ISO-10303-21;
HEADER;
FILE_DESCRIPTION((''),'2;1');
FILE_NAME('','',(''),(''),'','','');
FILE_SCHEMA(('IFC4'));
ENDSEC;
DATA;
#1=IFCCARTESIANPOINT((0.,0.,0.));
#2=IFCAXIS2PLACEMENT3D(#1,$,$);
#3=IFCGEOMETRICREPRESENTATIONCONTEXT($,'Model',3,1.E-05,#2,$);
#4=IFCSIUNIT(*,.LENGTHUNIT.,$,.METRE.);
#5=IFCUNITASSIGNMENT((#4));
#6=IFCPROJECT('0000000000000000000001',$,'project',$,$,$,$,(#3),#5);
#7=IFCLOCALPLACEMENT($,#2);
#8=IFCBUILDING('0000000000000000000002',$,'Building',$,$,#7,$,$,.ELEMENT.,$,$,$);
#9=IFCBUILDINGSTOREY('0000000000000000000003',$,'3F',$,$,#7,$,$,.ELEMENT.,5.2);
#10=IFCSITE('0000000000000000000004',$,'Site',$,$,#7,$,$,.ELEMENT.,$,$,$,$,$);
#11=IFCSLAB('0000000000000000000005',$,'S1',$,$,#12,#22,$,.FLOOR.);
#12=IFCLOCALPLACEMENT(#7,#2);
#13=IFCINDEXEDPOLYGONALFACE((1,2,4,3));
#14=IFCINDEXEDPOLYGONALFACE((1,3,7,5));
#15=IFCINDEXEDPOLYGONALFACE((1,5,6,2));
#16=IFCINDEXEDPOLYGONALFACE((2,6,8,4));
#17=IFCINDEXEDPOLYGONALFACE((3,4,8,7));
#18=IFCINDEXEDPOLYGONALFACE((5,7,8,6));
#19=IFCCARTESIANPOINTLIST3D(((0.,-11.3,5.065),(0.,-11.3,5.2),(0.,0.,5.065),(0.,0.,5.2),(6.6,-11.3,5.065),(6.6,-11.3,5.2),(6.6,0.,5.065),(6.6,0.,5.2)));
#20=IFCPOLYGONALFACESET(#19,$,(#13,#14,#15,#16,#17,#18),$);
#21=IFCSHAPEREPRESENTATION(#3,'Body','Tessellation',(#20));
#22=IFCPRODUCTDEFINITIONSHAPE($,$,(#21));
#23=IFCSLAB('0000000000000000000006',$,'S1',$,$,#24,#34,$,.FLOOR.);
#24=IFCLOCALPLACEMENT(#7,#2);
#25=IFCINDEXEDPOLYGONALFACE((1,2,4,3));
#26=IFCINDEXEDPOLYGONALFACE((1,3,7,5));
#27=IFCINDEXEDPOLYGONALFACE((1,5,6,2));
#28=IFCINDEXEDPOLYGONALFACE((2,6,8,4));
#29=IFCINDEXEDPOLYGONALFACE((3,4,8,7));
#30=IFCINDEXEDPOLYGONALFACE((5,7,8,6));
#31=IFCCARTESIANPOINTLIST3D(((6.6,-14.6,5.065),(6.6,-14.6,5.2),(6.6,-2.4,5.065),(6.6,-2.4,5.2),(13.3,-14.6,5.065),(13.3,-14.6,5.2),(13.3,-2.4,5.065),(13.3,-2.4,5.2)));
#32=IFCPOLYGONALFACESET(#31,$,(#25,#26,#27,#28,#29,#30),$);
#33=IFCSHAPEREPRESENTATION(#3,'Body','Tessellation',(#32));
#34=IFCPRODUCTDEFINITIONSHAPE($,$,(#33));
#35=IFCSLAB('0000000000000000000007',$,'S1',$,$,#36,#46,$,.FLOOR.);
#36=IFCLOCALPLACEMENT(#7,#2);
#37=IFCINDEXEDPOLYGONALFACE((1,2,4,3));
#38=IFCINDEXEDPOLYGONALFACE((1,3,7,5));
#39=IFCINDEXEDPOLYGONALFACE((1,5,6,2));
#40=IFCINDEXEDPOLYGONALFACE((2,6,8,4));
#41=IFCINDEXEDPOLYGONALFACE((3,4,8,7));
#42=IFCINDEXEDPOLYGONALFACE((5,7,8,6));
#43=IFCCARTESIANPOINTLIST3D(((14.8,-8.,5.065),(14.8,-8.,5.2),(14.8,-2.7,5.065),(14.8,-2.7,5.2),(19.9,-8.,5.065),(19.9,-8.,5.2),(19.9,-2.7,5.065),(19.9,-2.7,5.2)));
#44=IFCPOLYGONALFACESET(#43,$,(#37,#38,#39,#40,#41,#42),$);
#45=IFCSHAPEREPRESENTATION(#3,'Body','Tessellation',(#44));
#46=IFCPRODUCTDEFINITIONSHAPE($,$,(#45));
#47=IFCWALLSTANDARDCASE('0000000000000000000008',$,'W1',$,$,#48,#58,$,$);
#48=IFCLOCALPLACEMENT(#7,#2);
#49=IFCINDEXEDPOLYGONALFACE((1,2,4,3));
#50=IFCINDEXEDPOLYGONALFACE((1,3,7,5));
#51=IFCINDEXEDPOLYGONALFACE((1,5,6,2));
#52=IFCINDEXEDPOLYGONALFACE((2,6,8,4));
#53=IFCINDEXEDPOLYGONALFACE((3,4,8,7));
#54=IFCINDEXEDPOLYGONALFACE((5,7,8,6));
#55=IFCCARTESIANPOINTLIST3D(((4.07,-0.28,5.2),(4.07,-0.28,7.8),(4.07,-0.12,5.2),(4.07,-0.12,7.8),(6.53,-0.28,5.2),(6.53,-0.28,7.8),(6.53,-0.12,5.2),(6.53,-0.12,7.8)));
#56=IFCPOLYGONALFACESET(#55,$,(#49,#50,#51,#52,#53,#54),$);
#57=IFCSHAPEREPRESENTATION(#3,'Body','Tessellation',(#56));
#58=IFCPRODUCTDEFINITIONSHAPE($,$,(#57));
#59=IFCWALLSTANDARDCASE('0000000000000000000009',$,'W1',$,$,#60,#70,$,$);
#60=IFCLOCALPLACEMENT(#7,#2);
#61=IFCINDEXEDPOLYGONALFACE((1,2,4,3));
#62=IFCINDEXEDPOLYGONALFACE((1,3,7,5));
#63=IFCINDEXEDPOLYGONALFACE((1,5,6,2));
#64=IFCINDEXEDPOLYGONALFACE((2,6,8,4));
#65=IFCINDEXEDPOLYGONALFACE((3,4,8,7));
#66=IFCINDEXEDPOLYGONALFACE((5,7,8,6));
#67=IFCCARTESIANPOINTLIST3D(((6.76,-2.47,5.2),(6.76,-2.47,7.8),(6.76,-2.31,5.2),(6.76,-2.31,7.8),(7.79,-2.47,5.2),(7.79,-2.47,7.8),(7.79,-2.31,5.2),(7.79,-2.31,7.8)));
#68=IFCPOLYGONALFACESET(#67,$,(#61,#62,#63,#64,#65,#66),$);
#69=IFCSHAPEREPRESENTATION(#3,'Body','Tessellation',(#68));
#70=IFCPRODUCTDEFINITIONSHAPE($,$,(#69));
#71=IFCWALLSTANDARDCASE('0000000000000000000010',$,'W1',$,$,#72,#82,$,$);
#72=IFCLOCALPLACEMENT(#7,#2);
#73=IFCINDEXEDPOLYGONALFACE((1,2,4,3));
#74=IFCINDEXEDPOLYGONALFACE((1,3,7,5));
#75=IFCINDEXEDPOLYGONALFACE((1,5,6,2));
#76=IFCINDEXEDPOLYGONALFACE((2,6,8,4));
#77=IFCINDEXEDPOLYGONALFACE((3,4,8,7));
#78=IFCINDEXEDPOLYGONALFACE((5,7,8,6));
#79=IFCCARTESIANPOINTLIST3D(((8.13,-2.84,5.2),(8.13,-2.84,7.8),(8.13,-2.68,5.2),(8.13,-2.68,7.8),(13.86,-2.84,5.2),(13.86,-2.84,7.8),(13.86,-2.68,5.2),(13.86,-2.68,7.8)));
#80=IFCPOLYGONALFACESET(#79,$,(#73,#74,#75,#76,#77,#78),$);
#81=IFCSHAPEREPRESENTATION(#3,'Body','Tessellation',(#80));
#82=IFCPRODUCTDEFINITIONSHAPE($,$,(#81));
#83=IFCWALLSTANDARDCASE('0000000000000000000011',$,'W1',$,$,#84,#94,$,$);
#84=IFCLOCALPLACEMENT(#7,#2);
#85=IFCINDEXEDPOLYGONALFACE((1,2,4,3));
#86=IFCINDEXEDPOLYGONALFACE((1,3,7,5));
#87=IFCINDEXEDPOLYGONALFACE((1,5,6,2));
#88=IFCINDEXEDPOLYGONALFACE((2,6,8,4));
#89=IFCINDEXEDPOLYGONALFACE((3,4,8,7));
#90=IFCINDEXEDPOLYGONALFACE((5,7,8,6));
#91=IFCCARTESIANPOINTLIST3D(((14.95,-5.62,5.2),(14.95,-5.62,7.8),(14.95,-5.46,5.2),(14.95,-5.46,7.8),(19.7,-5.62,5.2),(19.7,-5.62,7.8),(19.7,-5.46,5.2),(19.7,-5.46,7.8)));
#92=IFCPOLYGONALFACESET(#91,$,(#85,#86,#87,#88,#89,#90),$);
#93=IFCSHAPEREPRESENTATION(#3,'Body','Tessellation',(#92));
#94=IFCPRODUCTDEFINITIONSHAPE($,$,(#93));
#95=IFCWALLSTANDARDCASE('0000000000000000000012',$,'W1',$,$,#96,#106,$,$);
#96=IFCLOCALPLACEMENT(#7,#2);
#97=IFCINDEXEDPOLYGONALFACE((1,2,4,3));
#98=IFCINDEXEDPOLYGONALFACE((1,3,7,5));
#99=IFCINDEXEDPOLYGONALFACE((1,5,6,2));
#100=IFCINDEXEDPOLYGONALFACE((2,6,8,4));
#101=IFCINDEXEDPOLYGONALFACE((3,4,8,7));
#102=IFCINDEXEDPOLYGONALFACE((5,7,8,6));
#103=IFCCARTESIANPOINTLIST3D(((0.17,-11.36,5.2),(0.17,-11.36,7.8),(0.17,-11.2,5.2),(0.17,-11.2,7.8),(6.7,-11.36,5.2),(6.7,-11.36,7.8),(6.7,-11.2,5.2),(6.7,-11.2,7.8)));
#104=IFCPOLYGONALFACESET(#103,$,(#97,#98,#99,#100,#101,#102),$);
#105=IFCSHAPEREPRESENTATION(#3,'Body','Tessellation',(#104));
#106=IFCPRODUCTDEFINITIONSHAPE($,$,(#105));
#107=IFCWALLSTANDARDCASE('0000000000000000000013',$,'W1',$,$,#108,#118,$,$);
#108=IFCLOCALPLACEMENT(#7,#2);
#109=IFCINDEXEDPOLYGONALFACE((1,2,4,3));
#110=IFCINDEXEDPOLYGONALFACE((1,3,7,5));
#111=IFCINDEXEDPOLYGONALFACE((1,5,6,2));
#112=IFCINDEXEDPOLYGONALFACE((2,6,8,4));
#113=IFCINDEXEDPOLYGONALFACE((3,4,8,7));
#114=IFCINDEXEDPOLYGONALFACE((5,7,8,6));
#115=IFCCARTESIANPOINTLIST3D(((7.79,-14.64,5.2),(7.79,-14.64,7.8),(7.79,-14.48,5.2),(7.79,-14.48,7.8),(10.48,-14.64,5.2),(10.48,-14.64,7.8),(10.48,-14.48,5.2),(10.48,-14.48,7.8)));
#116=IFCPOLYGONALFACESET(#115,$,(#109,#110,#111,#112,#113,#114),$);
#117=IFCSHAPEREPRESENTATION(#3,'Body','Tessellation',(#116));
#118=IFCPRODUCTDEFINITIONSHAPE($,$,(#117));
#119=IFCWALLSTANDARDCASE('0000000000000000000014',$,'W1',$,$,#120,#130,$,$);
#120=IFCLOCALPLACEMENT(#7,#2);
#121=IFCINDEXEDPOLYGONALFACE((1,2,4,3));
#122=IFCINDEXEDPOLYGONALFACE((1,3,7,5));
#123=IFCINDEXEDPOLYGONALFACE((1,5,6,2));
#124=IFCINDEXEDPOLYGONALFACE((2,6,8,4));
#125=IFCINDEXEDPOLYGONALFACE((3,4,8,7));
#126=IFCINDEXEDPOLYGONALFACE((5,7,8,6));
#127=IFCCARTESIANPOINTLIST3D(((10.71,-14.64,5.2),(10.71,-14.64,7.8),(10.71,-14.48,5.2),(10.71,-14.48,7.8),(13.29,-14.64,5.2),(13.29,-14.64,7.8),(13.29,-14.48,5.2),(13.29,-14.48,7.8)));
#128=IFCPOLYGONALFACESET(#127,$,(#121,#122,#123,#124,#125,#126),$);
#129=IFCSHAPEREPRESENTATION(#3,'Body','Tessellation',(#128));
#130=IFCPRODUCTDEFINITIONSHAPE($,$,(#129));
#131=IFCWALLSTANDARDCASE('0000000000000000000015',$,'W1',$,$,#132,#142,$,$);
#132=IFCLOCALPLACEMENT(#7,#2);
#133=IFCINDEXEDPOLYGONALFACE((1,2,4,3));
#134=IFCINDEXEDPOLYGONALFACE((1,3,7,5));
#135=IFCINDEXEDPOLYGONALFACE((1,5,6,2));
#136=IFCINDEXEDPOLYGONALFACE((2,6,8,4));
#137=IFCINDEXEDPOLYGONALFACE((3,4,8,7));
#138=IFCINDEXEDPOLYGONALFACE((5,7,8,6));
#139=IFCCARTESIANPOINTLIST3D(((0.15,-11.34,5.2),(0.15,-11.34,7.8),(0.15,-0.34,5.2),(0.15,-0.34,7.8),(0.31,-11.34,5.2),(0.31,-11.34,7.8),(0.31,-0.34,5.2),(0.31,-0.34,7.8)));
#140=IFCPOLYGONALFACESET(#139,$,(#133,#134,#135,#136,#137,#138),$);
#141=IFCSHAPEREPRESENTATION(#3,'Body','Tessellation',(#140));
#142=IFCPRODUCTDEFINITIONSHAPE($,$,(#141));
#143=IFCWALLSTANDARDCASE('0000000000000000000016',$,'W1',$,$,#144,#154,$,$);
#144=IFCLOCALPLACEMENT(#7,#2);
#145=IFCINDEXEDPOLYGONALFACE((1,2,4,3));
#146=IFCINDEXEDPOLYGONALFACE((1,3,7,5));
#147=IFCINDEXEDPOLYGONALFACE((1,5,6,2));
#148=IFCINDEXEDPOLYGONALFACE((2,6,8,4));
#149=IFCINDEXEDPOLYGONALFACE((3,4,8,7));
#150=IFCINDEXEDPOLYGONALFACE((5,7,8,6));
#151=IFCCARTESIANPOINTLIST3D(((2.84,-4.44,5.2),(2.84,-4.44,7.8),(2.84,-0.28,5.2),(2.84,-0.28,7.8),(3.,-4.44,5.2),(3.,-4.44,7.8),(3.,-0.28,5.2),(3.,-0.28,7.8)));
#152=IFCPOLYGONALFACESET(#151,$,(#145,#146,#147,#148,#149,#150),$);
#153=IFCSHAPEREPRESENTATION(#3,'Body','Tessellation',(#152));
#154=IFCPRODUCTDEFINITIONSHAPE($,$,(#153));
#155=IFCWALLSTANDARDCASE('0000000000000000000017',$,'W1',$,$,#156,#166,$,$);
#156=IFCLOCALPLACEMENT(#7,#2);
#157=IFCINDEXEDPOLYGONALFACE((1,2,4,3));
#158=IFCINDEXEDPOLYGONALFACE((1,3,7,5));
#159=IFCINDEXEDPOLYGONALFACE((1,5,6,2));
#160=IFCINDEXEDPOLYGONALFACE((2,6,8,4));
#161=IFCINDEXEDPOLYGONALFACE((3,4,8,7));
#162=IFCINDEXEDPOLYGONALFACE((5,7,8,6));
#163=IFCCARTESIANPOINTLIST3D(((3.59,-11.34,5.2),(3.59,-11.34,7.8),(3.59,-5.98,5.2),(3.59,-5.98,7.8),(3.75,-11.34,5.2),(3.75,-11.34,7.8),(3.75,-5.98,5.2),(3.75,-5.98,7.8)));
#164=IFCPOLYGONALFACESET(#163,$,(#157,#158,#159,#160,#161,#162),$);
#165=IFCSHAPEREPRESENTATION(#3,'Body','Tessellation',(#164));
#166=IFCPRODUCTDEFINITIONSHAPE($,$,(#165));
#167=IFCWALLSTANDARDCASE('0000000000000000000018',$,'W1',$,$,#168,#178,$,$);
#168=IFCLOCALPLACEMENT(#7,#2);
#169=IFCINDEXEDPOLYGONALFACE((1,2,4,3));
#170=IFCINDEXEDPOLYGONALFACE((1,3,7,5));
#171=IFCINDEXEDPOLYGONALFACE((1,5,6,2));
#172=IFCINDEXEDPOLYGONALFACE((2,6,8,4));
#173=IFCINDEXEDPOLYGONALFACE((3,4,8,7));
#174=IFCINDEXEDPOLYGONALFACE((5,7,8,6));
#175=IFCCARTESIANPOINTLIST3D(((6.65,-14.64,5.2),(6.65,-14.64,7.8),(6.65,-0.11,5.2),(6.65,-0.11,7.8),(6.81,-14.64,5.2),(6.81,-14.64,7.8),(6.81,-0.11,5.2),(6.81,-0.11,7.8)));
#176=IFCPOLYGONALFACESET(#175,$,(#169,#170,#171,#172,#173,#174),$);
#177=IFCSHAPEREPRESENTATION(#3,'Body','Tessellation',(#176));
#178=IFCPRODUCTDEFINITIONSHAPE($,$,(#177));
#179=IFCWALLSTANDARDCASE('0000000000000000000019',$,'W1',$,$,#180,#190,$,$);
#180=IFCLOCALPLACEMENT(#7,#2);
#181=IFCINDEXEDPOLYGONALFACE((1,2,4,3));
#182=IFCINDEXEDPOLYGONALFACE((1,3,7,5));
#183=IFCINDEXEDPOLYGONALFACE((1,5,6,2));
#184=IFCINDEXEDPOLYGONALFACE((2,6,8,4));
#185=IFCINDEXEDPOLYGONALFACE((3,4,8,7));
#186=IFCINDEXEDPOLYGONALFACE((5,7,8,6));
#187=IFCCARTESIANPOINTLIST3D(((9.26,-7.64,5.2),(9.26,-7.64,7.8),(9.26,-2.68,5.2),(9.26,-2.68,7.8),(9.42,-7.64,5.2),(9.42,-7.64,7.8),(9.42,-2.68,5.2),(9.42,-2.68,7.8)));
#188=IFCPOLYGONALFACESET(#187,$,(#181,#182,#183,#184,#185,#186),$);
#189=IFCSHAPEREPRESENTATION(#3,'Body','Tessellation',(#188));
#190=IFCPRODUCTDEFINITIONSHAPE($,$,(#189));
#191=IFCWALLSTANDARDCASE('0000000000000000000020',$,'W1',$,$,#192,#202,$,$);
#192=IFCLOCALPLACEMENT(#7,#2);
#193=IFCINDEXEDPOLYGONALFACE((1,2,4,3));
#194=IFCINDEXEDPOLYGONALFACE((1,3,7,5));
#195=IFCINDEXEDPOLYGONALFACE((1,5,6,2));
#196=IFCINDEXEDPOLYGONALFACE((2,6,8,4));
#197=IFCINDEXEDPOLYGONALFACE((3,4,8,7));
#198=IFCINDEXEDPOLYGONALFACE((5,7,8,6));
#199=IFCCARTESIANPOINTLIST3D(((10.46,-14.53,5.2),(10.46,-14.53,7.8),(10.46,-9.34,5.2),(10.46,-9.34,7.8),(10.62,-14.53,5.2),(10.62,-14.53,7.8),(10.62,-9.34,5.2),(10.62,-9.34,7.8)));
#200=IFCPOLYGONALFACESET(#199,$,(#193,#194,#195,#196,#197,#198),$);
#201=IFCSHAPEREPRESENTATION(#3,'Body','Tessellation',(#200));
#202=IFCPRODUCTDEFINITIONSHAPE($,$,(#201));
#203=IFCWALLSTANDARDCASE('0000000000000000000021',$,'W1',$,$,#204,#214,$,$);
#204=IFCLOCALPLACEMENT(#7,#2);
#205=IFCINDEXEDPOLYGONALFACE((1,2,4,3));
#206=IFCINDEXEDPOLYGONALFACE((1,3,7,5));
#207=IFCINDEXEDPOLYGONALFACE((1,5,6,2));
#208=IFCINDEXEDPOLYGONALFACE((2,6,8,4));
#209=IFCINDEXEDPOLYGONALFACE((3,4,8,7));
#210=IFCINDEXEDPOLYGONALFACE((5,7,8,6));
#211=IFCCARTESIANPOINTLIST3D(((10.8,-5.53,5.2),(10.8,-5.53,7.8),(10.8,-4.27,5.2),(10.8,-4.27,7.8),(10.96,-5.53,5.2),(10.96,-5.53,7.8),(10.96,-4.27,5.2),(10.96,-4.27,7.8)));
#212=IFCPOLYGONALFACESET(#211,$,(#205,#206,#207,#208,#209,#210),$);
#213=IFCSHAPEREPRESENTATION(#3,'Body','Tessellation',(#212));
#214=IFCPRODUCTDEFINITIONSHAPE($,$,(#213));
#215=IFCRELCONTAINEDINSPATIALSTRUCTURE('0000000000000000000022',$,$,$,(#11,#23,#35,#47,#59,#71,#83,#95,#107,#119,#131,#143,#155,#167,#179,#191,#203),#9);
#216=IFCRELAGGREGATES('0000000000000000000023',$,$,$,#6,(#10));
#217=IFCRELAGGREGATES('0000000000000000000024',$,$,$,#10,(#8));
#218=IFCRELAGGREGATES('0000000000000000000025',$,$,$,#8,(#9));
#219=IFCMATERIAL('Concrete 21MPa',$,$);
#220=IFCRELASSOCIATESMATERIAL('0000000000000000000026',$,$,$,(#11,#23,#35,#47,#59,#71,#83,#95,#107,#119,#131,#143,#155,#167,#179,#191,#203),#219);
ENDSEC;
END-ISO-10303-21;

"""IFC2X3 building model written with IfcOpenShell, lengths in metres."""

from ifc_helpers import new_model, si_unit, frame, origin, origin_2d, place, context, project, spatial, rectangle, extrude, material, element, save


model = new_model("IFC2X3")

# Units and contexts
model_context = context("Model", 3, precision=1e-05, world=origin())
ifc_project = project(units=[si_unit("LENGTHUNIT", "METRE")], contexts=[model_context])

# Site, building, storey
placement = place(None, origin())
site = spatial("IfcSite", under=ifc_project, at=placement, Name="Site", CompositionType="ELEMENT")
building = spatial("IfcBuilding", under=site, at=placement, Name="Building", CompositionType="ELEMENT")
storey = spatial("IfcBuildingStorey", under=building, at=placement, Name="3F", CompositionType="ELEMENT", Elevation=5.2)

# Slabs
ifc_material_1 = material(Name="Concrete 21MPa")
slab_1_placement = place(None, frame((3.3, -5.65, 5.065)))
element("IfcSlab", 1, at=slab_1_placement, inside=storey, material=ifc_material_1, Name="S1", PredefinedType="FLOOR", context=model_context, shape_type="SweptSolid", body=[
    extrude(rectangle(XDim=6.6, YDim=11.3, at=origin_2d()), origin(), (0.0, 0.0, 1.0), 0.135),
])
slab_2_placement = place(None, frame((9.95, -8.5, 5.065)))
element("IfcSlab", 2, at=slab_2_placement, inside=storey, material=ifc_material_1, Name="S1", PredefinedType="FLOOR", context=model_context, shape_type="SweptSolid", body=[
    extrude(rectangle(XDim=6.7, YDim=12.2, at=origin_2d()), origin(), (0.0, 0.0, 1.0), 0.135),
])
slab_3_placement = place(None, frame((17.35, -5.35, 5.065)))
element("IfcSlab", 3, at=slab_3_placement, inside=storey, material=ifc_material_1, Name="S1", PredefinedType="FLOOR", context=model_context, shape_type="SweptSolid", body=[
    extrude(rectangle(XDim=5.1, YDim=5.3, at=origin_2d()), origin(), (0.0, 0.0, 1.0), 0.135),
])

# Walls
wall_1_placement = place(None, frame((5.3, -0.2, 5.2)))
element("IfcWallStandardCase", 4, at=wall_1_placement, inside=storey, material=ifc_material_1, Name="W1", context=model_context, shape_type="SweptSolid", body=[
    extrude(rectangle(XDim=2.46, YDim=0.16, at=origin_2d()), origin(), (0.0, 0.0, 1.0), 2.6),
])
wall_2_placement = place(None, frame((7.275, -2.39, 5.2)))
element("IfcWallStandardCase", 5, at=wall_2_placement, inside=storey, material=ifc_material_1, Name="W1", context=model_context, shape_type="SweptSolid", body=[
    extrude(rectangle(XDim=1.03, YDim=0.16, at=origin_2d()), origin(), (0.0, 0.0, 1.0), 2.6),
])
wall_3_placement = place(None, frame((10.995, -2.76, 5.2)))
element("IfcWallStandardCase", 6, at=wall_3_placement, inside=storey, material=ifc_material_1, Name="W1", context=model_context, shape_type="SweptSolid", body=[
    extrude(rectangle(XDim=5.73, YDim=0.16, at=origin_2d()), origin(), (0.0, 0.0, 1.0), 2.6),
])
wall_4_placement = place(None, frame((17.325, -5.54, 5.2)))
element("IfcWallStandardCase", 7, at=wall_4_placement, inside=storey, material=ifc_material_1, Name="W1", context=model_context, shape_type="SweptSolid", body=[
    extrude(rectangle(XDim=4.75, YDim=0.16, at=origin_2d()), origin(), (0.0, 0.0, 1.0), 2.6),
])
wall_5_placement = place(None, frame((3.435, -11.28, 5.2)))
element("IfcWallStandardCase", 8, at=wall_5_placement, inside=storey, material=ifc_material_1, Name="W1", context=model_context, shape_type="SweptSolid", body=[
    extrude(rectangle(XDim=6.53, YDim=0.16, at=origin_2d()), origin(), (0.0, 0.0, 1.0), 2.6),
])
wall_6_placement = place(None, frame((9.135, -14.56, 5.2)))
element("IfcWallStandardCase", 9, at=wall_6_placement, inside=storey, material=ifc_material_1, Name="W1", context=model_context, shape_type="SweptSolid", body=[
    extrude(rectangle(XDim=2.69, YDim=0.16, at=origin_2d()), origin(), (0.0, 0.0, 1.0), 2.6),
])
wall_7_placement = place(None, frame((12.0, -14.56, 5.2)))
element("IfcWallStandardCase", 10, at=wall_7_placement, inside=storey, material=ifc_material_1, Name="W1", context=model_context, shape_type="SweptSolid", body=[
    extrude(rectangle(XDim=2.58, YDim=0.16, at=origin_2d()), origin(), (0.0, 0.0, 1.0), 2.6),
])
wall_8_placement = place(None, frame((0.23, -5.84, 5.2)))
element("IfcWallStandardCase", 11, at=wall_8_placement, inside=storey, material=ifc_material_1, Name="W1", context=model_context, shape_type="SweptSolid", body=[
    extrude(rectangle(XDim=0.16, YDim=11.0, at=origin_2d()), origin(), (0.0, 0.0, 1.0), 2.6),
])
wall_9_placement = place(None, frame((2.92, -2.36, 5.2)))
element("IfcWallStandardCase", 12, at=wall_9_placement, inside=storey, material=ifc_material_1, Name="W1", context=model_context, shape_type="SweptSolid", body=[
    extrude(rectangle(XDim=0.16, YDim=4.16, at=origin_2d()), origin(), (0.0, 0.0, 1.0), 2.6),
])
wall_10_placement = place(None, frame((3.67, -8.66, 5.2)))
element("IfcWallStandardCase", 13, at=wall_10_placement, inside=storey, material=ifc_material_1, Name="W1", context=model_context, shape_type="SweptSolid", body=[
    extrude(rectangle(XDim=0.16, YDim=5.36, at=origin_2d()), origin(), (0.0, 0.0, 1.0), 2.6),
])
wall_11_placement = place(None, frame((6.73, -7.375, 5.2)))
element("IfcWallStandardCase", 14, at=wall_11_placement, inside=storey, material=ifc_material_1, Name="W1", context=model_context, shape_type="SweptSolid", body=[
    extrude(rectangle(XDim=0.16, YDim=14.53, at=origin_2d()), origin(), (0.0, 0.0, 1.0), 2.6),
])
wall_12_placement = place(None, frame((9.34, -5.16, 5.2)))
element("IfcWallStandardCase", 15, at=wall_12_placement, inside=storey, material=ifc_material_1, Name="W1", context=model_context, shape_type="SweptSolid", body=[
    extrude(rectangle(XDim=0.16, YDim=4.96, at=origin_2d()), origin(), (0.0, 0.0, 1.0), 2.6),
])
wall_13_placement = place(None, frame((10.54, -11.935, 5.2)))
element("IfcWallStandardCase", 16, at=wall_13_placement, inside=storey, material=ifc_material_1, Name="W1", context=model_context, shape_type="SweptSolid", body=[
    extrude(rectangle(XDim=0.16, YDim=5.19, at=origin_2d()), origin(), (0.0, 0.0, 1.0), 2.6),
])
wall_14_placement = place(None, frame((10.88, -4.9, 5.2)))
element("IfcWallStandardCase", 17, at=wall_14_placement, inside=storey, material=ifc_material_1, Name="W1", context=model_context, shape_type="SweptSolid", body=[
    extrude(rectangle(XDim=0.16, YDim=1.26, at=origin_2d()), origin(), (0.0, 0.0, 1.0), 2.6),
])

save(model, "model.ifc")
